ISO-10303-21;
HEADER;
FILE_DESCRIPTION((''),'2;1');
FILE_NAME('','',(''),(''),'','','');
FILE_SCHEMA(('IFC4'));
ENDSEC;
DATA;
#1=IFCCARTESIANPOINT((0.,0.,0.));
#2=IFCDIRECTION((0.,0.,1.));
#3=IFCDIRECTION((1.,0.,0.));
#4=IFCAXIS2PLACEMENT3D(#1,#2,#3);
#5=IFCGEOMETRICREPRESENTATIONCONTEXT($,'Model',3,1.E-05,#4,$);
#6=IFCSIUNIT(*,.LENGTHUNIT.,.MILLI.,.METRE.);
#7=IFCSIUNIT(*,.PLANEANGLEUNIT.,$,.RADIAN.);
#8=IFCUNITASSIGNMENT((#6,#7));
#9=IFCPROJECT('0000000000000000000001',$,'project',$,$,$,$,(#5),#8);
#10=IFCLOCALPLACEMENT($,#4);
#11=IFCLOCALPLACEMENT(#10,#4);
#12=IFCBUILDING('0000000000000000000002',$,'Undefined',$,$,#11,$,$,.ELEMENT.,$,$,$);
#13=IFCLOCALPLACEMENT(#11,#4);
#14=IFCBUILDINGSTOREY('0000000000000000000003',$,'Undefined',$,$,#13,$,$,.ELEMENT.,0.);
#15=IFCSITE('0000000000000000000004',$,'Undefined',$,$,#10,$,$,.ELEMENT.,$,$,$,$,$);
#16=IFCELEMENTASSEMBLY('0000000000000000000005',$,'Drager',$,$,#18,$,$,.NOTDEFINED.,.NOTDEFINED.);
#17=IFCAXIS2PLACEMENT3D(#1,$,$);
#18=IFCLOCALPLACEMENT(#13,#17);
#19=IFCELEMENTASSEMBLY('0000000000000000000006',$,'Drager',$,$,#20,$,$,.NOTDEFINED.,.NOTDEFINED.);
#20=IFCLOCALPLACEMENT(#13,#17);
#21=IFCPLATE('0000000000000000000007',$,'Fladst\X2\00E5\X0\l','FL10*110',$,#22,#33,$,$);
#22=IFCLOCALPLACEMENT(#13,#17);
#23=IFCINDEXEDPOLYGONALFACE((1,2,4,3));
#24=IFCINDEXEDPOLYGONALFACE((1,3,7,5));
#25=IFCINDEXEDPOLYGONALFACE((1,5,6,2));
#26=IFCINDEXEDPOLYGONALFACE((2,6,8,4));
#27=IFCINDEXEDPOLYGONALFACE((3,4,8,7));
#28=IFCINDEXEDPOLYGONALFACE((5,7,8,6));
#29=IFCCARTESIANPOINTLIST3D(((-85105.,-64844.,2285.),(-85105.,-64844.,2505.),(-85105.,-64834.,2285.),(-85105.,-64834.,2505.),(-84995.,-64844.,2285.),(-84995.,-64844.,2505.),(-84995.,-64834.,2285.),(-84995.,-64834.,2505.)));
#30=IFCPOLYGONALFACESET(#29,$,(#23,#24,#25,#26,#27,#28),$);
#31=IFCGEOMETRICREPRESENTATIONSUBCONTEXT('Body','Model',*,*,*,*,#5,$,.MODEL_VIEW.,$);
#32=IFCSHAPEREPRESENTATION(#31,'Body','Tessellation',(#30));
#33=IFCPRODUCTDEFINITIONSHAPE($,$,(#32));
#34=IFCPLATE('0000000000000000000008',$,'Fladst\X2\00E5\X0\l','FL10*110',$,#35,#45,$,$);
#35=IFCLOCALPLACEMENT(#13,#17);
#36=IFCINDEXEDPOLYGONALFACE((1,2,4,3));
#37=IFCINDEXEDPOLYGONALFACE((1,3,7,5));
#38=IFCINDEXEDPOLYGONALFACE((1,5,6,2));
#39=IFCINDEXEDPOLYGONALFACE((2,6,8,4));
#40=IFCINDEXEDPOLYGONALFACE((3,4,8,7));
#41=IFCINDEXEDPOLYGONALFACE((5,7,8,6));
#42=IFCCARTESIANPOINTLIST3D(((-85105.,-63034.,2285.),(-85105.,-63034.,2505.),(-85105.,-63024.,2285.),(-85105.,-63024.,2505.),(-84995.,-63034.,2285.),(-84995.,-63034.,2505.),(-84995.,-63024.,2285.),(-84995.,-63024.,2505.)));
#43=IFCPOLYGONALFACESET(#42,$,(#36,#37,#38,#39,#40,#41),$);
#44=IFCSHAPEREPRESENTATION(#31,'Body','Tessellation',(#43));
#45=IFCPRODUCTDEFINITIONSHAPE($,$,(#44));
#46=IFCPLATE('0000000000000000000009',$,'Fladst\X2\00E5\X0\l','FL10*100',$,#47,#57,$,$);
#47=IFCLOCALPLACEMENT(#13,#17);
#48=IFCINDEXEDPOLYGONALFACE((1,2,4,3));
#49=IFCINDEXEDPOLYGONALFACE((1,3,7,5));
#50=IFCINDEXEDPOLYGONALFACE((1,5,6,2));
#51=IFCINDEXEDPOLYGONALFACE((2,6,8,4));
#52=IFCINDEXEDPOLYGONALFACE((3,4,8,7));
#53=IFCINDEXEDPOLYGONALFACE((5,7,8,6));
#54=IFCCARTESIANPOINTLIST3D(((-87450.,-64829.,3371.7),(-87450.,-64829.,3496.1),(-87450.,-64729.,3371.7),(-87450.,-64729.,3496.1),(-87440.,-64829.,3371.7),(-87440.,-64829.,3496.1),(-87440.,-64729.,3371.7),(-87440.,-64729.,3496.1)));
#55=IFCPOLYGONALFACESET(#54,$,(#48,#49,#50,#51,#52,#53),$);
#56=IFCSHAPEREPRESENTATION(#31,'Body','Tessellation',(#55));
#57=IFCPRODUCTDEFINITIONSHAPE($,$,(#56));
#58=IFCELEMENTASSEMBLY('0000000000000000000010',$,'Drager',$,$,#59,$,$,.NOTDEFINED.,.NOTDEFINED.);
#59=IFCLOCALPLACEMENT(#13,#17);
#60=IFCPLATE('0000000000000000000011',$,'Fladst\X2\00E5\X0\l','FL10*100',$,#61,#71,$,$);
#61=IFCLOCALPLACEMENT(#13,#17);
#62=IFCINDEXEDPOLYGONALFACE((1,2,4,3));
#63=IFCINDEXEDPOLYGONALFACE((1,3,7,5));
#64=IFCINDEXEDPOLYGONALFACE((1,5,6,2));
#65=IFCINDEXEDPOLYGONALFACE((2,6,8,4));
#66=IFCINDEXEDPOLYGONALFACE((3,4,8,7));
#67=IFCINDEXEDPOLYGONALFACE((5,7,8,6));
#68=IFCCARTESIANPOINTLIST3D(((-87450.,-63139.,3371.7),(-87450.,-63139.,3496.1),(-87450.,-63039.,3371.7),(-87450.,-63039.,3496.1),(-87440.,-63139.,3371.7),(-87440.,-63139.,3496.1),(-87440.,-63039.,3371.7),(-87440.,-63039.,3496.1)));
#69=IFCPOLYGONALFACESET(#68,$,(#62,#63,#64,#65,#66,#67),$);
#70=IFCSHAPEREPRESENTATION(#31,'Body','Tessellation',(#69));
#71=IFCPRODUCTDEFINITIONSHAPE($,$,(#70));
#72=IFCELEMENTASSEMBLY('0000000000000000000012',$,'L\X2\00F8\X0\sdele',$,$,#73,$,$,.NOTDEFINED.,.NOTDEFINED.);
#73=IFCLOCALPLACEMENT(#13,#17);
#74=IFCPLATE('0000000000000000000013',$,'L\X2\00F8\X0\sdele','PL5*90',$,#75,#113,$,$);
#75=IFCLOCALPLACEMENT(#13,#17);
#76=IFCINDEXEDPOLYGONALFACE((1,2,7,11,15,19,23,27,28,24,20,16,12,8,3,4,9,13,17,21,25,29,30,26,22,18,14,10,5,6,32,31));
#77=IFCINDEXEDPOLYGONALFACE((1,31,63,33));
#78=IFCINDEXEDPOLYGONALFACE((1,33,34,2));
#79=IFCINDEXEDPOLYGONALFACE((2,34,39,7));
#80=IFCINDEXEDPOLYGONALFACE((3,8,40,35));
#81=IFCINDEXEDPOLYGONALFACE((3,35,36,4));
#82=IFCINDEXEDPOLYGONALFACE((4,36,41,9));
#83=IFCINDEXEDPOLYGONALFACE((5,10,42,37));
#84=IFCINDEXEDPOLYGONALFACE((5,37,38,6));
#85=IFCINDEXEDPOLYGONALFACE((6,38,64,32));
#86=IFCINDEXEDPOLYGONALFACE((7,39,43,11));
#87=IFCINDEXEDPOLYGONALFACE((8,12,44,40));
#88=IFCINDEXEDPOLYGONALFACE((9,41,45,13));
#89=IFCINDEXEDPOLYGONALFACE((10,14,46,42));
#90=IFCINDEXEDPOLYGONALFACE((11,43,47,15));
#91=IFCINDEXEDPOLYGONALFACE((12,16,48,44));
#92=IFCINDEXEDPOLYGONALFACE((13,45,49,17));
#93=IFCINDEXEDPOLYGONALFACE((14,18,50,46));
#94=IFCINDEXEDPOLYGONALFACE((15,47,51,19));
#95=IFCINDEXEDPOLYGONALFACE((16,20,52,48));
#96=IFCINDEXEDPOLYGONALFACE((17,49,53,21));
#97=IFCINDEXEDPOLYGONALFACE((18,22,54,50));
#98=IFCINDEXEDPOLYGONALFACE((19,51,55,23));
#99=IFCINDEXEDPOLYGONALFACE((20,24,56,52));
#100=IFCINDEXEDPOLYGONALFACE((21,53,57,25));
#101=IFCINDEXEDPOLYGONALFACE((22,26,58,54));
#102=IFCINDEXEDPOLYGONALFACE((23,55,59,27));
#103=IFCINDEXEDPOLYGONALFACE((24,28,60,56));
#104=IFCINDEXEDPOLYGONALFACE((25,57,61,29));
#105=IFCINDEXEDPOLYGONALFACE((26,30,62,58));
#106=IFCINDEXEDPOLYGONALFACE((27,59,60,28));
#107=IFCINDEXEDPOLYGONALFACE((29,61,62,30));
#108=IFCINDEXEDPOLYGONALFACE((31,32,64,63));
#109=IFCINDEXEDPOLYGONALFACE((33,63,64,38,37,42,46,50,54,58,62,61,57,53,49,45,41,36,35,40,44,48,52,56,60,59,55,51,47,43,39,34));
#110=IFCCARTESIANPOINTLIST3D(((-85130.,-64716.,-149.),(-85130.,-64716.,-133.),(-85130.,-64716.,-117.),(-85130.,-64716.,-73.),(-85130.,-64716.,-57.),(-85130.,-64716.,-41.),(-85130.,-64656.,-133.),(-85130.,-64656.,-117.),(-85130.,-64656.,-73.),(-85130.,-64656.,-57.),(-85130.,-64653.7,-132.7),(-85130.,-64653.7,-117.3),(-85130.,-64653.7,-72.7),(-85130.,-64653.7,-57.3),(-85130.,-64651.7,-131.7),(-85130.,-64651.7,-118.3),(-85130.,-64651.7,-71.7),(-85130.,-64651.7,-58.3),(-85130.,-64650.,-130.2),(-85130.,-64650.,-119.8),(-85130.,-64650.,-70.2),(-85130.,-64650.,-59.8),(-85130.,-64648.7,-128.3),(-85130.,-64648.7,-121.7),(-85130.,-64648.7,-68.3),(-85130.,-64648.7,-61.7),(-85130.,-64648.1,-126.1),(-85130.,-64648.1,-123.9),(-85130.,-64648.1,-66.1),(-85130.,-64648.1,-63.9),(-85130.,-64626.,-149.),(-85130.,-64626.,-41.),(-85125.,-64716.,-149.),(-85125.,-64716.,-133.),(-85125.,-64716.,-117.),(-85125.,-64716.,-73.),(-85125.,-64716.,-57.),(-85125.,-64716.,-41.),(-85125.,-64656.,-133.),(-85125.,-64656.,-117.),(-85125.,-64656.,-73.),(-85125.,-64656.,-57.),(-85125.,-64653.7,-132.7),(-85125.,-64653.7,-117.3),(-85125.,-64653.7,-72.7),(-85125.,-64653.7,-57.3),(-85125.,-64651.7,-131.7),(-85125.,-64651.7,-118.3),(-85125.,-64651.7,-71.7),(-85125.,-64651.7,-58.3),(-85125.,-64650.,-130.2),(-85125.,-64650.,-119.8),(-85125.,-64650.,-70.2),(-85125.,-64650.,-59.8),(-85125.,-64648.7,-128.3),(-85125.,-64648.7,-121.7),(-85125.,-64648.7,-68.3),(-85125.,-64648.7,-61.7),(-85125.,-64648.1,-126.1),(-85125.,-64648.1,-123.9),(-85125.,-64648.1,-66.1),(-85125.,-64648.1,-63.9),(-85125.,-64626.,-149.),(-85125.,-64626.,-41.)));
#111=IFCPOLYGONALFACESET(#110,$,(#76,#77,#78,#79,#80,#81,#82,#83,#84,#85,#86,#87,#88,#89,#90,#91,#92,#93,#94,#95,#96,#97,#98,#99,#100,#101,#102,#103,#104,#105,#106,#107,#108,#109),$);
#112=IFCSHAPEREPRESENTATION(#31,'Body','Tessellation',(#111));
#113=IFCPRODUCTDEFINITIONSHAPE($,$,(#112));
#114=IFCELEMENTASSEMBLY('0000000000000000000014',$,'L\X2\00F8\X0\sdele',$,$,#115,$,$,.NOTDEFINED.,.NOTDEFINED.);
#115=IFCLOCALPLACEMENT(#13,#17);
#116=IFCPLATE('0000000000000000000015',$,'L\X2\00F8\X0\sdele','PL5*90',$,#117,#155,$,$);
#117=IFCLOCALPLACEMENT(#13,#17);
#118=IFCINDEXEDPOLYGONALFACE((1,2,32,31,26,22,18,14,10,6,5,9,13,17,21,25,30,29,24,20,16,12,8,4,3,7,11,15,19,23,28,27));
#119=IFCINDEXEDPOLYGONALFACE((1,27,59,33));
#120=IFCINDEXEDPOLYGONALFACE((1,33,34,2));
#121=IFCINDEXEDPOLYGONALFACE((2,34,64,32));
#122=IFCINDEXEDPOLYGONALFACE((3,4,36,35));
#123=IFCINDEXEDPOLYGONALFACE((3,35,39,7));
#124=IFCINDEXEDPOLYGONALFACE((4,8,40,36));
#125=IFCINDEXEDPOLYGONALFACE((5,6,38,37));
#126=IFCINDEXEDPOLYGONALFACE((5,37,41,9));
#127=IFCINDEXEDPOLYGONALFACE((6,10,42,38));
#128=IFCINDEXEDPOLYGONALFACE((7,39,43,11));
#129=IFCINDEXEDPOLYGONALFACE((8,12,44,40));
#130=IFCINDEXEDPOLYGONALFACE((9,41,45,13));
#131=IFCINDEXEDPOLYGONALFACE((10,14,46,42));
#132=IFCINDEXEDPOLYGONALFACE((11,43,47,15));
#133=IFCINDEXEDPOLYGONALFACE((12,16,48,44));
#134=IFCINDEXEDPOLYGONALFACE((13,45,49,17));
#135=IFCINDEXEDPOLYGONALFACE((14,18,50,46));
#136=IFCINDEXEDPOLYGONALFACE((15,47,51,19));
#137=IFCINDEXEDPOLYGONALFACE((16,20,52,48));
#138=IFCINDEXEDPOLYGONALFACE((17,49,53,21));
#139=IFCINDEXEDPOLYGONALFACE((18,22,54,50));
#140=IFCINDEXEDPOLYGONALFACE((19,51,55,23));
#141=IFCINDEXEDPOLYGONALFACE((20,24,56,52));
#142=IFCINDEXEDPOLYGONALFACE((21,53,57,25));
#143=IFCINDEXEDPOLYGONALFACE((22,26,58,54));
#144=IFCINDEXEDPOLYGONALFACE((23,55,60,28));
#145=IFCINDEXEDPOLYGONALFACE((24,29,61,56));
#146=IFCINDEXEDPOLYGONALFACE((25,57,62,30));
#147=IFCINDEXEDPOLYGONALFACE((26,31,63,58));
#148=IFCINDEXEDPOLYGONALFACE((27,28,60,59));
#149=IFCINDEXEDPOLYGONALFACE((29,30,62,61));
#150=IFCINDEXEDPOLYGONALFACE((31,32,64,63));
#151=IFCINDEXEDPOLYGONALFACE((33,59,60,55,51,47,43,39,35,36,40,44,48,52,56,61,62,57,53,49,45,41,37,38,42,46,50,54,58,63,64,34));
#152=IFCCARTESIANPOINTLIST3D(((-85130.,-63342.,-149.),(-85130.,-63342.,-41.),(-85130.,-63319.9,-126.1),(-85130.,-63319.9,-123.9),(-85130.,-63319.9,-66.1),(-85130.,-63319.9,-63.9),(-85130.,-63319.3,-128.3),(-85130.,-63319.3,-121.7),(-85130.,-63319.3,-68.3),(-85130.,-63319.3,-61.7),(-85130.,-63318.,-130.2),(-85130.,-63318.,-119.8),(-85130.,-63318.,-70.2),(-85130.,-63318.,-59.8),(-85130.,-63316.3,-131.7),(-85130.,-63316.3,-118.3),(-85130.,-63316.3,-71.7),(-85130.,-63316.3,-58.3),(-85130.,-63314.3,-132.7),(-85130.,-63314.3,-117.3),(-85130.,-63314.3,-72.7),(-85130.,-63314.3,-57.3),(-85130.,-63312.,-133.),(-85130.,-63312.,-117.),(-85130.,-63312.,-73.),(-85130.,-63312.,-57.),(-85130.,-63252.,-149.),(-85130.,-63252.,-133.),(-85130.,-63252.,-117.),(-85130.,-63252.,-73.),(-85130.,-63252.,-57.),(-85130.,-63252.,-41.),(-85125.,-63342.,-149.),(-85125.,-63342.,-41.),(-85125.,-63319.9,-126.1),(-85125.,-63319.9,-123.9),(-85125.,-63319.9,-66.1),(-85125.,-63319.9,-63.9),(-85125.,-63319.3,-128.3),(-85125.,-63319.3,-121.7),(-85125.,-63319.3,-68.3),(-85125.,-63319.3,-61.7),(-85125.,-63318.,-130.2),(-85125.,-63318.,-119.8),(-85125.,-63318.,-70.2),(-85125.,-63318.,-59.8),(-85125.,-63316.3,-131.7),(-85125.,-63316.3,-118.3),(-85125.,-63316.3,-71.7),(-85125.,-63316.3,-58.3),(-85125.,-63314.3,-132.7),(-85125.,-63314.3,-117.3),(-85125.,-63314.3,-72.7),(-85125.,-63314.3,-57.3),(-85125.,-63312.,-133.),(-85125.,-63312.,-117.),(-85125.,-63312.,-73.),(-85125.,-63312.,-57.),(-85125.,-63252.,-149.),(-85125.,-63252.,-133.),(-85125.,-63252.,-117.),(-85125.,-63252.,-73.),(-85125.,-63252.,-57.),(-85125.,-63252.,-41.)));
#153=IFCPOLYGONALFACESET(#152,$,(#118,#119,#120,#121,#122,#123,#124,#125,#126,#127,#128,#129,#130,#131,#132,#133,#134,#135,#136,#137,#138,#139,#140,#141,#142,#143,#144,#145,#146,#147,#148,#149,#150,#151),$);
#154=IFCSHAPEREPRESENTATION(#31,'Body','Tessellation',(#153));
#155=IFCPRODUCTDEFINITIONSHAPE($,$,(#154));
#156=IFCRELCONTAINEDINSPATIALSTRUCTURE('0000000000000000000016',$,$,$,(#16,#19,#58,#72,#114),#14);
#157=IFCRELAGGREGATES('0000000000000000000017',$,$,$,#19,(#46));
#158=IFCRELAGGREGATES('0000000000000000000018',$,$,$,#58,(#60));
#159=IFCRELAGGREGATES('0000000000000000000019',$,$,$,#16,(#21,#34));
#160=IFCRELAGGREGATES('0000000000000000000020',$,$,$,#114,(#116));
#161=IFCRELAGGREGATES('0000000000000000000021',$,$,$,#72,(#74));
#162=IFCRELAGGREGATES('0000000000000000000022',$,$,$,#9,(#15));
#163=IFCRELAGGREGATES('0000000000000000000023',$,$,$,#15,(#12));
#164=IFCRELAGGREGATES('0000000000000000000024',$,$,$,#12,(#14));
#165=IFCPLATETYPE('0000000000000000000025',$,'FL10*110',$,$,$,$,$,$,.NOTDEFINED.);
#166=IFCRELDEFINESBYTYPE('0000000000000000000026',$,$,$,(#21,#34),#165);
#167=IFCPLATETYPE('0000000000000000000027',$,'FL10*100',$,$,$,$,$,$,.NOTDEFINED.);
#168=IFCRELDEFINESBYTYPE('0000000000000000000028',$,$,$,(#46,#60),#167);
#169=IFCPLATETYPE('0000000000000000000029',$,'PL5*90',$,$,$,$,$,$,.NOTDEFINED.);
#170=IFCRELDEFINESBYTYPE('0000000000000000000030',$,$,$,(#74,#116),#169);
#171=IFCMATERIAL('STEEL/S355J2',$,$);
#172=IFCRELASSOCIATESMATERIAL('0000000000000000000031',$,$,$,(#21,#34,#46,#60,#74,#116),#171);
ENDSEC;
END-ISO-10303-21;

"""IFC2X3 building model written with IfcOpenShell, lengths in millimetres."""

from ifc_helpers import new_model, si_unit, frame, frame_2d, origin_with_axes, place, context, subcontext, project, spatial, polyline, circle_curve, parameter, trimmed, segment, composite_curve, outline, extrude, boolean, material, type_object, element, aggregate, save


model = new_model("IFC2X3")

# Units and contexts
model_context = context("Model", 3, precision=1e-05, world=origin_with_axes())
body_context = subcontext(model_context, "Body", "Model", "MODEL_VIEW")
ifc_project = project(units=[si_unit("LENGTHUNIT", "METRE", prefix="MILLI"), si_unit("PLANEANGLEUNIT", "RADIAN")], contexts=[model_context])

# Site, building, storey
site_placement = place(None, origin_with_axes())
site = spatial("IfcSite", under=ifc_project, at=site_placement, Name="Undefined", CompositionType="ELEMENT")
building_placement = place(site_placement, origin_with_axes())
building = spatial("IfcBuilding", under=site, at=building_placement, Name="Undefined", CompositionType="ELEMENT")
storey_placement = place(building_placement, origin_with_axes())
storey = spatial("IfcBuildingStorey", under=building, at=storey_placement, Name="Undefined", CompositionType="ELEMENT", Elevation=0.0)

# Element assembly
assembly_1_placement = place(storey_placement, origin_with_axes())
assembly_1 = element("IfcElementAssembly", 1, at=assembly_1_placement, inside=storey, Name="Drager", AssemblyPlace="NOTDEFINED", PredefinedType="NOTDEFINED")

# Element assembly
assembly_2_placement = place(storey_placement, origin_with_axes())
assembly_2 = element("IfcElementAssembly", 2, at=assembly_2_placement, inside=storey, Name="Drager", AssemblyPlace="NOTDEFINED", PredefinedType="NOTDEFINED")
ifc_material_1 = material(Name="STEEL/S355J2")

# Plates
plate_type_1 = type_object("IfcPlateType", Name="FL10*110", PredefinedType="NOTDEFINED")
plate_1_placement = place(assembly_1_placement, frame((-85050.0, -64839.0, 2285.0), z_axis=(0.0, -1.0, 0.0), x_axis=(0.0, 0.0, 1.0)))
plate_1 = element("IfcPlate", 3, at=plate_1_placement, type_object=plate_type_1, material=ifc_material_1, Name="Fladstål", Description="FL10*110", context=body_context, shape_type="SweptSolid", body=[
    extrude(outline(polyline([(0.0, -55.0), (0.0, 55.0), (220.0, 55.0), (220.0, -55.0), (0.0, -55.0)])), frame((0.0, 0.0, -5.0), z_axis=(0.0, 0.0, 1.0), x_axis=(1.0, 0.0, 0.0)), (0.0, 0.0, 1.0), 10.0),
])
plate_2_placement = place(assembly_1_placement, frame((-85050.0, -63029.0, 2285.0), z_axis=(0.0, -1.0, 0.0), x_axis=(0.0, 0.0, 1.0)))
plate_2 = element("IfcPlate", 4, at=plate_2_placement, type_object=plate_type_1, material=ifc_material_1, Name="Fladstål", Description="FL10*110", context=body_context, shape_type="SweptSolid", body=[
    extrude(outline(polyline([(0.0, -55.0), (0.0, 55.0), (220.0, 55.0), (220.0, -55.0), (0.0, -55.0)])), frame((0.0, 0.0, -5.0), z_axis=(0.0, 0.0, 1.0), x_axis=(1.0, 0.0, 0.0)), (0.0, 0.0, 1.0), 10.0),
])
plate_type_2 = type_object("IfcPlateType", Name="FL10*100", PredefinedType="NOTDEFINED")
plate_3_placement = place(assembly_2_placement, frame((-87445.0, -64779.0, 3371.7), z_axis=(-1.0, 0.0, 0.0), x_axis=(0.0, 0.0, 1.0)))
plate_3 = element("IfcPlate", 5, at=plate_3_placement, type_object=plate_type_2, material=ifc_material_1, Name="Fladstål", Description="FL10*100", context=body_context, shape_type="SweptSolid", body=[
    extrude(outline(polyline([(0.0, -50.0), (0.0, 50.0), (124.4, 50.0), (124.4, -50.0), (0.0, -50.0)])), frame((0.0, 0.0, -5.0), z_axis=(0.0, 0.0, 1.0), x_axis=(1.0, 0.0, 0.0)), (0.0, 0.0, 1.0), 10.0),
])
aggregate(assembly_2, [plate_3])

# Element assemblies, plates
assembly_3_placement = place(storey_placement, origin_with_axes())
assembly_3 = element("IfcElementAssembly", 6, at=assembly_3_placement, inside=storey, Name="Drager", AssemblyPlace="NOTDEFINED", PredefinedType="NOTDEFINED")
plate_4_placement = place(assembly_3_placement, frame((-87445.0, -63089.0, 3371.7), z_axis=(1.0, 0.0, 0.0), x_axis=(0.0, 0.0, 1.0)))
plate_4 = element("IfcPlate", 7, at=plate_4_placement, type_object=plate_type_2, material=ifc_material_1, Name="Fladstål", Description="FL10*100", context=body_context, shape_type="SweptSolid", body=[
    extrude(outline(polyline([(0.0, -50.0), (0.0, 50.0), (124.4, 50.0), (124.4, -50.0), (0.0, -50.0)])), frame((0.0, 0.0, -5.0), z_axis=(0.0, 0.0, 1.0), x_axis=(1.0, 0.0, 0.0)), (0.0, 0.0, 1.0), 10.0),
])
aggregate(assembly_3, [plate_4])
assembly_4_placement = place(storey_placement, origin_with_axes())
assembly_4 = element("IfcElementAssembly", 8, at=assembly_4_placement, inside=storey, Name="Løsdele", AssemblyPlace="NOTDEFINED", PredefinedType="NOTDEFINED")
plate_type_3 = type_object("IfcPlateType", Name="PL5*90", PredefinedType="NOTDEFINED")
plate_5_placement = place(assembly_4_placement, frame((-85127.5, -64671.0, -41.0), z_axis=(-1.0, 0.0, 0.0), x_axis=(0.0, 0.0, -1.0)))
plate_5 = element("IfcPlate", 9, at=plate_5_placement, type_object=plate_type_3, material=ifc_material_1, Name="Løsdele", Description="PL5*90", context=body_context, shape_type="CSG", body=[
    boolean("DIFFERENCE", boolean("DIFFERENCE", extrude(outline(polyline([(0.0, -45.0), (0.0, 45.0), (108.0, 45.0), (108.0, -45.0), (0.0, -45.0)])), frame((0.0, 0.0, -2.5), z_axis=(0.0, 0.0, 1.0), x_axis=(1.0, 0.0, 0.0)), (0.0, 0.0, 1.0), 5.0), extrude(outline(composite_curve([segment(polyline([(0.0, 0.0), (60.0, 0.0), (60.0, 16.0), (0.0, 16.0)]), True, "CONTINUOUS"), segment(trimmed(circle_curve(frame_2d((0.0, 8.0), x_axis=(0.0, 1.0)), 8.0), [parameter(0.0)], [parameter(1.570796)], True, "PARAMETER"), True, "CONTINUOUS"), segment(polyline([(-8.0, 8.0), (-8.0, 8.0)]), True, "CONTINUOUS"), segment(trimmed(circle_curve(frame_2d((0.0, 8.0), x_axis=(-1.0, 0.0)), 8.0), [parameter(0.0)], [parameter(1.570796)], True, "PARAMETER"), True, "CONTINUOUS"), segment(polyline([(0.0, 0.0), (0.0, 0.0)]), True, "CONTINUOUS")], self_intersect=True)), frame((92.0, -15.0, -2.5), z_axis=(0.0, 0.0, 1.0), x_axis=(0.0, 1.0, 0.0)), (0.0, 0.0, 1.0), 5.0)), extrude(outline(composite_curve([segment(polyline([(0.0, 0.0), (60.0, 0.0), (60.0, 16.0), (0.0, 16.0)]), True, "CONTINUOUS"), segment(trimmed(circle_curve(frame_2d((0.0, 8.0), x_axis=(0.0, 1.0)), 8.0), [parameter(0.0)], [parameter(1.570796)], True, "PARAMETER"), True, "CONTINUOUS"), segment(polyline([(-8.0, 8.0), (-8.0, 8.0)]), True, "CONTINUOUS"), segment(trimmed(circle_curve(frame_2d((0.0, 8.0), x_axis=(-1.0, 0.0)), 8.0), [parameter(0.0)], [parameter(1.570796)], True, "PARAMETER"), True, "CONTINUOUS"), segment(polyline([(0.0, 0.0), (0.0, 0.0)]), True, "CONTINUOUS")], self_intersect=True)), frame((32.0, -15.0, -2.5), z_axis=(0.0, 0.0, 1.0), x_axis=(0.0, 1.0, 0.0)), (0.0, 0.0, 1.0), 5.0)),
])
assembly_5_placement = place(storey_placement, origin_with_axes())
assembly_5 = element("IfcElementAssembly", 10, at=assembly_5_placement, inside=storey, Name="Løsdele", AssemblyPlace="NOTDEFINED", PredefinedType="NOTDEFINED")
plate_6_placement = place(assembly_5_placement, frame((-85127.5, -63297.0, -149.0), z_axis=(-1.0, 0.0, 0.0), x_axis=(0.0, 0.0, 1.0)))
plate_6 = element("IfcPlate", 11, at=plate_6_placement, type_object=plate_type_3, material=ifc_material_1, Name="Løsdele", Description="PL5*90", context=body_context, shape_type="CSG", body=[
    boolean("DIFFERENCE", boolean("DIFFERENCE", extrude(outline(polyline([(0.0, -45.0), (0.0, 45.0), (108.0, 45.0), (108.0, -45.0), (0.0, -45.0)])), frame((0.0, 0.0, -2.5), z_axis=(0.0, 0.0, 1.0), x_axis=(1.0, 0.0, 0.0)), (0.0, 0.0, 1.0), 5.0), extrude(outline(composite_curve([segment(polyline([(0.0, 0.0), (60.0, 0.0), (60.0, 16.0), (0.0, 16.0)]), True, "CONTINUOUS"), segment(trimmed(circle_curve(frame_2d((0.0, 8.0), x_axis=(0.0, 1.0)), 8.0), [parameter(0.0)], [parameter(1.570796)], True, "PARAMETER"), True, "CONTINUOUS"), segment(polyline([(-8.0, 8.0), (-8.0, 8.0)]), True, "CONTINUOUS"), segment(trimmed(circle_curve(frame_2d((0.0, 8.0), x_axis=(-1.0, 0.0)), 8.0), [parameter(0.0)], [parameter(1.570796)], True, "PARAMETER"), True, "CONTINUOUS"), segment(polyline([(0.0, 0.0), (0.0, 0.0)]), True, "CONTINUOUS")], self_intersect=True)), frame((92.0, -15.0, -2.5), z_axis=(0.0, 0.0, 1.0), x_axis=(0.0, 1.0, 0.0)), (0.0, 0.0, 1.0), 5.0)), extrude(outline(composite_curve([segment(polyline([(0.0, 0.0), (60.0, 0.0), (60.0, 16.0), (0.0, 16.0)]), True, "CONTINUOUS"), segment(trimmed(circle_curve(frame_2d((0.0, 8.0), x_axis=(0.0, 1.0)), 8.0), [parameter(0.0)], [parameter(1.570796)], True, "PARAMETER"), True, "CONTINUOUS"), segment(polyline([(-8.0, 8.0), (-8.0, 8.0)]), True, "CONTINUOUS"), segment(trimmed(circle_curve(frame_2d((0.0, 8.0), x_axis=(-1.0, 0.0)), 8.0), [parameter(0.0)], [parameter(1.570796)], True, "PARAMETER"), True, "CONTINUOUS"), segment(polyline([(0.0, 0.0), (0.0, 0.0)]), True, "CONTINUOUS")], self_intersect=True)), frame((32.0, -15.0, -2.5), z_axis=(0.0, 0.0, 1.0), x_axis=(0.0, 1.0, 0.0)), (0.0, 0.0, 1.0), 5.0)),
])

aggregate(assembly_1, [plate_1, plate_2])

aggregate(assembly_5, [plate_6])
aggregate(assembly_4, [plate_5])

save(model, "model.ifc")
